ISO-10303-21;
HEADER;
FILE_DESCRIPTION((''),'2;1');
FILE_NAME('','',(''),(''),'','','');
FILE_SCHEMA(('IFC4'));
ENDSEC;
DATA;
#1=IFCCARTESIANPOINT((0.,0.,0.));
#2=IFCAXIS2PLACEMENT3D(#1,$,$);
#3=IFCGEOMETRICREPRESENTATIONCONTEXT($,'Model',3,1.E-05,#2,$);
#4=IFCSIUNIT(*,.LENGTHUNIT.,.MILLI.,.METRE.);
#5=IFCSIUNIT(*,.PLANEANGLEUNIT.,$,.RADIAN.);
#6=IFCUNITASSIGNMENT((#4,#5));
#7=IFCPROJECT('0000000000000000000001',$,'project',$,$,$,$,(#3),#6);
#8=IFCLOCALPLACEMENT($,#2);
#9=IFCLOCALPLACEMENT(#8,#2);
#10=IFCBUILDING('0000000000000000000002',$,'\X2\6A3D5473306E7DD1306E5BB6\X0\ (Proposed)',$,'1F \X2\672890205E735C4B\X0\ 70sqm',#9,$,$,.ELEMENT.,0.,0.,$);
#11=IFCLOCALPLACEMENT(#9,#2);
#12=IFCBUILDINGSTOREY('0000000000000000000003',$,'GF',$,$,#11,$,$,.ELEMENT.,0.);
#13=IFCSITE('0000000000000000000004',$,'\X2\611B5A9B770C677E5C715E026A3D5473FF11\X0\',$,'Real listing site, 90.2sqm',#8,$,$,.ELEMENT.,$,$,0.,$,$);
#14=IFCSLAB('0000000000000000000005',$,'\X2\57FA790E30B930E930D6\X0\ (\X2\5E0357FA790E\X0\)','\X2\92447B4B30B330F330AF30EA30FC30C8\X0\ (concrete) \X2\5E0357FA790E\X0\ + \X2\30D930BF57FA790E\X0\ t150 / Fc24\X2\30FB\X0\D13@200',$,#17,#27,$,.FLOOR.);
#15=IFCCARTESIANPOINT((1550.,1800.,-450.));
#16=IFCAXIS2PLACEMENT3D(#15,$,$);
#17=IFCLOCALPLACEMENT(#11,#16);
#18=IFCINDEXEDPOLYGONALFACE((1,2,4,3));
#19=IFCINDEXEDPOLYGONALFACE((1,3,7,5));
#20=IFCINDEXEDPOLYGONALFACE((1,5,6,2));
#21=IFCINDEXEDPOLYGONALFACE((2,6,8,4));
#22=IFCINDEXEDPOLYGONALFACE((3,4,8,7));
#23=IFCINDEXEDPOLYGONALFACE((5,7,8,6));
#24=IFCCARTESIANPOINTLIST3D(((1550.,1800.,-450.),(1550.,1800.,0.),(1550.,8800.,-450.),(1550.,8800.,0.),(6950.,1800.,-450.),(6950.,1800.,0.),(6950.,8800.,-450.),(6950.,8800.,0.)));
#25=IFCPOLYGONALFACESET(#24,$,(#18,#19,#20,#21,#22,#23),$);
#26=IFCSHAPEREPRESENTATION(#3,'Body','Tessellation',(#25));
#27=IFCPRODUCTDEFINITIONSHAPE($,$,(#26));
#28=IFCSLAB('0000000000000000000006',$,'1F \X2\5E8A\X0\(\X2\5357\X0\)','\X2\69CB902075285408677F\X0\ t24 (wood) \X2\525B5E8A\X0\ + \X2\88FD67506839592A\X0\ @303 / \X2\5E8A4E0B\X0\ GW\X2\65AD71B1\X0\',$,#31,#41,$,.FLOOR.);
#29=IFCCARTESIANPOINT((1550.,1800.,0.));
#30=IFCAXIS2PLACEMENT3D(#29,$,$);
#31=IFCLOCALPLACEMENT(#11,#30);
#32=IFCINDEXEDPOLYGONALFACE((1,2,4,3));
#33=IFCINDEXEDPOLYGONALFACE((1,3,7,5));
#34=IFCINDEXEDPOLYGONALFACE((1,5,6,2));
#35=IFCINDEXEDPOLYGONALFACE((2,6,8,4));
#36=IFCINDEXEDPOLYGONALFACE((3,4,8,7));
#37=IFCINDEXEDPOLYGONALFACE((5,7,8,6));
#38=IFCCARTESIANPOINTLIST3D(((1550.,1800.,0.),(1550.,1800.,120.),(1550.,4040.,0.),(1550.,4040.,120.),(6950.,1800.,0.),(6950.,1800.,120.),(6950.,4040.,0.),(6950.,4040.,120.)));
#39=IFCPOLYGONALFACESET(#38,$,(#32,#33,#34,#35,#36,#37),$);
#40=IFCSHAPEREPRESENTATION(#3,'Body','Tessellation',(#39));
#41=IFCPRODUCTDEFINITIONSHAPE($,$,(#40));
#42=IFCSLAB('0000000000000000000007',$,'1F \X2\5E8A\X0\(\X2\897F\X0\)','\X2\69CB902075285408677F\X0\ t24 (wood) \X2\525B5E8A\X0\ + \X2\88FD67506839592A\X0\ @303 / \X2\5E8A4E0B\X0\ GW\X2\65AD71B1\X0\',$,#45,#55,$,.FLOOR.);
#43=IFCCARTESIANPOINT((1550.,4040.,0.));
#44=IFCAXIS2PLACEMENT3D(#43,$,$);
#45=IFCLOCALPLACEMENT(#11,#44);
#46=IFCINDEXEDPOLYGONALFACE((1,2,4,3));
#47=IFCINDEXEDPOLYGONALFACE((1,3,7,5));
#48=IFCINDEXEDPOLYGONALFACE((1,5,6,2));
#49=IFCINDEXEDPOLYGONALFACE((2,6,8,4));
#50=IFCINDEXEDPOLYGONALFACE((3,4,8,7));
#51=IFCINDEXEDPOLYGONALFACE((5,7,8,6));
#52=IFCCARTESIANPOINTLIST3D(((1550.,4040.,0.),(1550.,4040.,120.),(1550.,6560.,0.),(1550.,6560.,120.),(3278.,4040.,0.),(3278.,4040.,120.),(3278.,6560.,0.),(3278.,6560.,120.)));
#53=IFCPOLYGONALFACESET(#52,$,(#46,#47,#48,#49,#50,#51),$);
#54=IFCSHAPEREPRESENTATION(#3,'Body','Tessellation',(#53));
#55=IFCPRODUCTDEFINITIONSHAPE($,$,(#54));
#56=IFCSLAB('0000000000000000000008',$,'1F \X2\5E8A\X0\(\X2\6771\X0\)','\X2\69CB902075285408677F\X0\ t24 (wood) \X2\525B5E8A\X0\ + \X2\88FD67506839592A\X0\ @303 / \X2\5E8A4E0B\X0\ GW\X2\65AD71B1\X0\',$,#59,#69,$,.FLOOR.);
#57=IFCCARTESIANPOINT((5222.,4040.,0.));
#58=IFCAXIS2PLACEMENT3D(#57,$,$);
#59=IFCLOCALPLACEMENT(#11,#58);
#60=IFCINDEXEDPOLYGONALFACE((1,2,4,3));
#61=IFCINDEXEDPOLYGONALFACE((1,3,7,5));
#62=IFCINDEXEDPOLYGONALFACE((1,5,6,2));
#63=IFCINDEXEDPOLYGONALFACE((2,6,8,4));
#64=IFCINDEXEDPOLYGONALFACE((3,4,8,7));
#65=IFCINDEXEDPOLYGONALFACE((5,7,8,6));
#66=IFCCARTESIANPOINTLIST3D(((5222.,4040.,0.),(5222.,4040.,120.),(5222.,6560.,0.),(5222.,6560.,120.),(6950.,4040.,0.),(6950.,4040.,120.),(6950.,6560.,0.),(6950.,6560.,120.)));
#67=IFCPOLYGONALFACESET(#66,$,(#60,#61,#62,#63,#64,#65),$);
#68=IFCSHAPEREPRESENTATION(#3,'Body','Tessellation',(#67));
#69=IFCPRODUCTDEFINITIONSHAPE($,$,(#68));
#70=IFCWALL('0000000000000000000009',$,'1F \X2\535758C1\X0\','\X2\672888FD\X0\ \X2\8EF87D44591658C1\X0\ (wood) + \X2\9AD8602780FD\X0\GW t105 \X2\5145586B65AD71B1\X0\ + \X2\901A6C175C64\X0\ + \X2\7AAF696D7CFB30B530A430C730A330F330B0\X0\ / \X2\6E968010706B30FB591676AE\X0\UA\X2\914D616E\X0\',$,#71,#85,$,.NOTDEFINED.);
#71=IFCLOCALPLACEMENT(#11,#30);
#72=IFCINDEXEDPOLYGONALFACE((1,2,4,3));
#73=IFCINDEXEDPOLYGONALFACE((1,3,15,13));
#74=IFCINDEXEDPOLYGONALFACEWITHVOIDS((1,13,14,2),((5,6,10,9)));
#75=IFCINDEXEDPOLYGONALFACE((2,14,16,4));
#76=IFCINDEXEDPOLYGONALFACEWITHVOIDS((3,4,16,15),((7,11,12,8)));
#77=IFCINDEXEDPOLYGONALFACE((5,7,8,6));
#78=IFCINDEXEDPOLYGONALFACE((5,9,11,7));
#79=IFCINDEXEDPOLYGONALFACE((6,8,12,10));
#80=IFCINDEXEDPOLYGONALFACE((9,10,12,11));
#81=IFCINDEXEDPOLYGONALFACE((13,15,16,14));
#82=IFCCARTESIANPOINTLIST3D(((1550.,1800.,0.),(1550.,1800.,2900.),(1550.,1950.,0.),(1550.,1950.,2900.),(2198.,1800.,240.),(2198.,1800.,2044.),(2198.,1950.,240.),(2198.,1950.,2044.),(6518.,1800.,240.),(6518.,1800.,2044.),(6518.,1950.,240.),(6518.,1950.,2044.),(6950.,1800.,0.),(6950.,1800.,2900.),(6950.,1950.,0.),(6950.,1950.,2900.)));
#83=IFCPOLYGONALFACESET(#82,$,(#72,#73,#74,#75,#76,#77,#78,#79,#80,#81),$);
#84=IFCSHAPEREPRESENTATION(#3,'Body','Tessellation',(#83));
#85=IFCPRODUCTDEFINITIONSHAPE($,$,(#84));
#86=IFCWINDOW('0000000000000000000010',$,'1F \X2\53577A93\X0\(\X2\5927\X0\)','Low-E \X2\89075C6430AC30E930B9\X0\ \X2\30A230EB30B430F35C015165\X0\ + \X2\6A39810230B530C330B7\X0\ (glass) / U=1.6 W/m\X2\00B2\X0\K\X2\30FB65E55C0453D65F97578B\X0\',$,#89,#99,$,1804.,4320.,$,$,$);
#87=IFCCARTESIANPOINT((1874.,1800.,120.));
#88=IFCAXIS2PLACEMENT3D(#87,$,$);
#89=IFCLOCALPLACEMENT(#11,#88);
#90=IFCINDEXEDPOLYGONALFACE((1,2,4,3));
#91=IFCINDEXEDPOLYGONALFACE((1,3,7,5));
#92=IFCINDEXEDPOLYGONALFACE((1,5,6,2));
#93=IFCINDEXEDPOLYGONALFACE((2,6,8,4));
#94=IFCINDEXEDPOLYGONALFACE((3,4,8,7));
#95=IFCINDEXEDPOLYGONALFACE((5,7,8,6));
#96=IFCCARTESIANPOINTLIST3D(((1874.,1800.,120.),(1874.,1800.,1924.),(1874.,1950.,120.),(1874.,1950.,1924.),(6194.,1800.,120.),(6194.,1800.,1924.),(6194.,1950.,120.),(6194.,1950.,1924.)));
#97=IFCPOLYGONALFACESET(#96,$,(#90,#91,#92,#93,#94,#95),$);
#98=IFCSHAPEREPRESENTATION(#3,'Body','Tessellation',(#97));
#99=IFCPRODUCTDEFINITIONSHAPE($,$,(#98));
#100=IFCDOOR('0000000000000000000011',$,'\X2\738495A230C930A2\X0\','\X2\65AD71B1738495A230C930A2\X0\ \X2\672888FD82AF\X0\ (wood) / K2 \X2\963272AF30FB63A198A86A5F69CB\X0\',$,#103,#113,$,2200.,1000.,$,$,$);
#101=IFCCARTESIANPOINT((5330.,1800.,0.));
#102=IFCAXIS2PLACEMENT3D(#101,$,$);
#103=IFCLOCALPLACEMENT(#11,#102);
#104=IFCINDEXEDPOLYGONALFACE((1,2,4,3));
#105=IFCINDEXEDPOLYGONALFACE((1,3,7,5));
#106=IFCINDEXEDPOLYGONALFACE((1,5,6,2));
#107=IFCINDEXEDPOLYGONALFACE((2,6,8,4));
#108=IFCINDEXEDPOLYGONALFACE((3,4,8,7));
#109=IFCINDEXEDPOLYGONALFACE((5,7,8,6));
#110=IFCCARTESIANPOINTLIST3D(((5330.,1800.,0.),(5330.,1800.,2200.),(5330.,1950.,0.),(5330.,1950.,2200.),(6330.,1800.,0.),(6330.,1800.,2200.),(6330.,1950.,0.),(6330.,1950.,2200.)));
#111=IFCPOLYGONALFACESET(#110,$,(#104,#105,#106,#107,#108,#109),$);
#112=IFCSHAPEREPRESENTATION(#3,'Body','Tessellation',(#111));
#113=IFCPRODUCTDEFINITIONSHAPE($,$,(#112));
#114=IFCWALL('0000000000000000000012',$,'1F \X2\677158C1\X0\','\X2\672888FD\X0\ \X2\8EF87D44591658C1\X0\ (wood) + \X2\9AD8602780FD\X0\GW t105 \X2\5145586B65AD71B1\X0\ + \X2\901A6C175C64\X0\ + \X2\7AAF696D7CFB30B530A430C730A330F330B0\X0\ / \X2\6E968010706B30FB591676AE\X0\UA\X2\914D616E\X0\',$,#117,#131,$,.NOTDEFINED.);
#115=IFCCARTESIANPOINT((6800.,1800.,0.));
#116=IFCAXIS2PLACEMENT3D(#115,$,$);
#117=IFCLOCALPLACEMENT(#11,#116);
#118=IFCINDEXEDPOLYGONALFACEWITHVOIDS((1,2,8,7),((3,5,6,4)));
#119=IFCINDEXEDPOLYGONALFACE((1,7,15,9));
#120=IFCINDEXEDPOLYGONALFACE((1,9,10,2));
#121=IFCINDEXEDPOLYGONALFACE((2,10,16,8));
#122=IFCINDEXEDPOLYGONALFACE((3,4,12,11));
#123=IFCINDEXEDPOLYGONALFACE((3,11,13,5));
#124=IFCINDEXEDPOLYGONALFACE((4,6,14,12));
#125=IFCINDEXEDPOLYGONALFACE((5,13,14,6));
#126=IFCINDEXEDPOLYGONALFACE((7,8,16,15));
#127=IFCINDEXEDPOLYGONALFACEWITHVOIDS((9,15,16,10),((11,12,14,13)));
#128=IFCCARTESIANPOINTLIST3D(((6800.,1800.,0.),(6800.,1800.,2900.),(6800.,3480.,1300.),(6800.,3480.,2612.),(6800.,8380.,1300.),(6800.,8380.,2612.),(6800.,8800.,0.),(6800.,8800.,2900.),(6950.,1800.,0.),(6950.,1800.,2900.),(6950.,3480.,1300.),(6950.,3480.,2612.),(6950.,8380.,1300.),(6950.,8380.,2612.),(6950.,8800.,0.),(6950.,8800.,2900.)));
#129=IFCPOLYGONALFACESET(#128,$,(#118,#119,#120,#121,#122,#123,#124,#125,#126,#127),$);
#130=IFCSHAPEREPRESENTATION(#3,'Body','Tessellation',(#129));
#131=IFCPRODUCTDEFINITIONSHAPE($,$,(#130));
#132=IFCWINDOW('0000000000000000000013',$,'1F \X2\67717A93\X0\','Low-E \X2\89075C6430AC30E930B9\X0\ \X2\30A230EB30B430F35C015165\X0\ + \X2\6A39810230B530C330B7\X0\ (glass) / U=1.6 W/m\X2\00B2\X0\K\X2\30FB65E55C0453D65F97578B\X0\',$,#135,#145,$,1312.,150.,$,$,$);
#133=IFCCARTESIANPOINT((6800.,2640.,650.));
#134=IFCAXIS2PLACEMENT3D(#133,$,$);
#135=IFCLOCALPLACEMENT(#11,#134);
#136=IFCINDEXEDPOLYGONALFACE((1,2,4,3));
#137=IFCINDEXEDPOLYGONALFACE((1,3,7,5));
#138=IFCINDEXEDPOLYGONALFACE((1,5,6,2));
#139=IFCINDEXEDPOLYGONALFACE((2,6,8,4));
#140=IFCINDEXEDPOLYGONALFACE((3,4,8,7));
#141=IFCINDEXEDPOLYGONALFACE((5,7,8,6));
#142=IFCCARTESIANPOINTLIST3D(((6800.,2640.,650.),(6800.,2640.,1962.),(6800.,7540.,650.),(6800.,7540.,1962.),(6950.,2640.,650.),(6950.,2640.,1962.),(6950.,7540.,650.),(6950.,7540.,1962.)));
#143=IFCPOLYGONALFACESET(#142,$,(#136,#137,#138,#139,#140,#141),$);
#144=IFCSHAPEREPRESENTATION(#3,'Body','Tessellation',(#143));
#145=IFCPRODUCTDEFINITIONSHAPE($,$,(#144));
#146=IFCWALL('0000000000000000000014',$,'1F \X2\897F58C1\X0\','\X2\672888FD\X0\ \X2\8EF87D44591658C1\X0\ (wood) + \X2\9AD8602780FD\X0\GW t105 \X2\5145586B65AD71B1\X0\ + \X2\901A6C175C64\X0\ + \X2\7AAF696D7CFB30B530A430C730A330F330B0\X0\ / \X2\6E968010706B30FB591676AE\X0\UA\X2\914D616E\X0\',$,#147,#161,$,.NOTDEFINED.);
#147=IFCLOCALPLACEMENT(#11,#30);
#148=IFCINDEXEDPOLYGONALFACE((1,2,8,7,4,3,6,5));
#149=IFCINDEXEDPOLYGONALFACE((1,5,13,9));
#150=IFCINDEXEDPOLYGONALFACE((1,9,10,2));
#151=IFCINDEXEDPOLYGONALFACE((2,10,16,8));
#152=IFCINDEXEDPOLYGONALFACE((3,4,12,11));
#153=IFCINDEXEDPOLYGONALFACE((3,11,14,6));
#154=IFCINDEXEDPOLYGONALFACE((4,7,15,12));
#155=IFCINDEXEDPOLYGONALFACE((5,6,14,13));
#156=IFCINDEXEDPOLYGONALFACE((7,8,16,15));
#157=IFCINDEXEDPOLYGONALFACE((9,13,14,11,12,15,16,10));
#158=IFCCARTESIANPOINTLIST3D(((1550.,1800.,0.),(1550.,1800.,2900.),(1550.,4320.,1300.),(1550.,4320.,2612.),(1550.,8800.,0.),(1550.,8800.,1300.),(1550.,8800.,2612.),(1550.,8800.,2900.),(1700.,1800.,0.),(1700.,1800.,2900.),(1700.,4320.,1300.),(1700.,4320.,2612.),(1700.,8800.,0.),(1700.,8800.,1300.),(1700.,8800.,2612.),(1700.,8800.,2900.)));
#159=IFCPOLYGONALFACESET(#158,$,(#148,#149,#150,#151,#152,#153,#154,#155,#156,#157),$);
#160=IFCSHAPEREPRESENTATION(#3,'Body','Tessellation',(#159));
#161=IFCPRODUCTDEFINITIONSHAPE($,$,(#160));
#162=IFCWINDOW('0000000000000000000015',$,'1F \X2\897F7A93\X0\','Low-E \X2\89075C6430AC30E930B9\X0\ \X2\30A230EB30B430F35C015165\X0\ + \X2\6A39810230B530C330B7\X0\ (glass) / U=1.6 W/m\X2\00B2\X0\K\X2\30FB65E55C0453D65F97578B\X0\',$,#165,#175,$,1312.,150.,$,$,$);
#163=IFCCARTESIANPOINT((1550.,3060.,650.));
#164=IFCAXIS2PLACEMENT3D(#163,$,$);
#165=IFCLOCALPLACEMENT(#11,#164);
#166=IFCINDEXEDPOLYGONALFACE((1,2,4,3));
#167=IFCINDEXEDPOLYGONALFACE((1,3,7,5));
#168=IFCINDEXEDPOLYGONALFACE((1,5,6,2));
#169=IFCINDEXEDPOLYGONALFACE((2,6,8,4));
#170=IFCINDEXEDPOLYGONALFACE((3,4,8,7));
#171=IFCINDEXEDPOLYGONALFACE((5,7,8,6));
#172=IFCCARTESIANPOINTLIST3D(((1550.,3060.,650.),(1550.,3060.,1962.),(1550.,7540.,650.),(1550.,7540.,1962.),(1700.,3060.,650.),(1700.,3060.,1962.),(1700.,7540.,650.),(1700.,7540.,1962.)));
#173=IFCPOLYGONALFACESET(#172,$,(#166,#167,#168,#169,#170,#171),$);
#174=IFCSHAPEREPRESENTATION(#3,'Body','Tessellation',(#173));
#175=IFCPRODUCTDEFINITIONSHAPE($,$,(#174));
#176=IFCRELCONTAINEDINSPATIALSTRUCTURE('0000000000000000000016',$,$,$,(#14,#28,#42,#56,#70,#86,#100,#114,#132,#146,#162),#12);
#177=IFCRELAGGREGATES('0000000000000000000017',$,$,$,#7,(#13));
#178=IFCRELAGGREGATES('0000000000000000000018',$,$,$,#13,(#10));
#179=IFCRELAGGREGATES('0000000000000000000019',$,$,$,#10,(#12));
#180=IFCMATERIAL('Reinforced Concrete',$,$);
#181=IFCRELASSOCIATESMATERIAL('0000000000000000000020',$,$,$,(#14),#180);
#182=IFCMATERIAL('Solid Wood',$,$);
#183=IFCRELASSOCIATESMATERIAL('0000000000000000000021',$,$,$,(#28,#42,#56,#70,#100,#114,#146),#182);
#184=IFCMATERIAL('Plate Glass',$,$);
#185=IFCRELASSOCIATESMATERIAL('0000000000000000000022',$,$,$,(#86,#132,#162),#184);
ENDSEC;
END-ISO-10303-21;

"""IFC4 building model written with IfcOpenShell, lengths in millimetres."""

from ifc_helpers import new_model, si_unit, frame, frame_2d, origin, place, context, project, spatial, rectangle, extrude, material, element, fill, save


model = new_model("IFC4")

# Units and contexts
model_context = context("Model", 3, precision=1e-05, world=origin())
ifc_project = project(units=[si_unit("LENGTHUNIT", "METRE", prefix="MILLI"), si_unit("PLANEANGLEUNIT", "RADIAN")], contexts=[model_context])

# Site, building, storey
site_placement = place(None, origin())
site = spatial("IfcSite", under=ifc_project, at=site_placement, Name="愛媛県松山市樽味１", ObjectType="Real listing site, 90.2sqm", CompositionType="ELEMENT", RefElevation=0.0)
building_placement = place(site_placement, origin())
building = spatial("IfcBuilding", under=site, at=building_placement, Name="樽味の緑の家 (Proposed)", ObjectType="1F 木造平屋 70sqm", CompositionType="ELEMENT", ElevationOfRefHeight=0.0, ElevationOfTerrain=0.0)
storey_placement = place(building_placement, origin())
storey = spatial("IfcBuildingStorey", under=building, at=storey_placement, Name="GF", CompositionType="ELEMENT", Elevation=0.0)

# Slabs
ifc_material_1 = material(Name="Reinforced Concrete")
slab_1_placement = place(storey_placement, frame((1550.0, 1800.0, -450.0)))
element("IfcSlab", 1, at=slab_1_placement, inside=storey, material=ifc_material_1, Name="基礎スラブ (布基礎)", Description="鉄筋コンクリート (concrete) 布基礎 + ベタ基礎 t150 / Fc24・D13@200", PredefinedType="FLOOR", context=model_context, shape_type="SweptSolid", body=[
    extrude(rectangle(XDim=5400.0, YDim=7000.0, at=frame_2d((2700.0, 3500.0))), frame((1550.0, 1800.0, -450.0)), (0.0, 0.0, 1.0), 450.0),
])
ifc_material_2 = material(Name="Solid Wood")
slab_2_placement = place(storey_placement, frame((1550.0, 1800.0, 0.0)))
element("IfcSlab", 2, at=slab_2_placement, inside=storey, material=ifc_material_2, Name="1F 床(南)", Description="構造用合板 t24 (wood) 剛床 + 製材根太 @303 / 床下 GW断熱", PredefinedType="FLOOR", context=model_context, shape_type="SweptSolid", body=[
    extrude(rectangle(XDim=5400.0, YDim=2240.0, at=frame_2d((2700.0, 1120.0))), frame((1550.0, 1800.0, 0.0)), (0.0, 0.0, 1.0), 120.0),
])
slab_3_placement = place(storey_placement, frame((1550.0, 4040.0, 0.0)))
element("IfcSlab", 3, at=slab_3_placement, inside=storey, material=ifc_material_2, Name="1F 床(西)", Description="構造用合板 t24 (wood) 剛床 + 製材根太 @303 / 床下 GW断熱", PredefinedType="FLOOR", context=model_context, shape_type="SweptSolid", body=[
    extrude(rectangle(XDim=1728.0, YDim=2520.0, at=frame_2d((864.0, 1260.0))), frame((1550.0, 4040.0, 0.0)), (0.0, 0.0, 1.0), 120.0),
])
slab_4_placement = place(storey_placement, frame((5222.0, 4040.0, 0.0)))
element("IfcSlab", 4, at=slab_4_placement, inside=storey, material=ifc_material_2, Name="1F 床(東)", Description="構造用合板 t24 (wood) 剛床 + 製材根太 @303 / 床下 GW断熱", PredefinedType="FLOOR", context=model_context, shape_type="SweptSolid", body=[
    extrude(rectangle(XDim=1728.0, YDim=2520.0, at=frame_2d((864.0, 1260.0))), frame((5222.0, 4040.0, 0.0)), (0.0, 0.0, 1.0), 120.0),
])

# Wall, openings, window, door
wall_1_placement = place(storey_placement, frame((1550.0, 1800.0, 0.0)))
wall_1 = element("IfcWall", 5, at=wall_1_placement, inside=storey, material=ifc_material_2, Name="1F 南壁", Description="木製 軸組外壁 (wood) + 高性能GW t105 充填断熱 + 通気層 + 窯業系サイディング / 準耐火・外皮UA配慮", PredefinedType="NOTDEFINED", context=model_context, shape_type="SweptSolid", body=[
    extrude(rectangle(XDim=5400.0, YDim=150.0, at=frame_2d((2700.0, 75.0))), frame((1550.0, 1800.0, 0.0)), (0.0, 0.0, 1.0), 2900.0),
])
opening_1_placement = place(storey_placement, frame((1874.0, 1800.0, 120.0)))
opening_1 = element("IfcOpeningElement", 6, at=opening_1_placement, cuts=wall_1, PredefinedType="NOTDEFINED", context=model_context, shape_type="SweptSolid", body=[
    extrude(rectangle(XDim=4320.0, YDim=150.0, at=frame_2d((2160.0, 75.0))), frame((1874.0, 1800.0, 120.0)), (0.0, 0.0, 1.0), 1804.0),
])
opening_2_placement = place(storey_placement, frame((5330.0, 1800.0, 0.0)))
opening_2 = element("IfcOpeningElement", 7, at=opening_2_placement, cuts=wall_1, PredefinedType="NOTDEFINED", context=model_context, shape_type="SweptSolid", body=[
    extrude(rectangle(XDim=1000.0, YDim=150.0, at=frame_2d((500.0, 75.0))), frame((5330.0, 1800.0, 0.0)), (0.0, 0.0, 1.0), 2200.0),
])
ifc_material_3 = material(Name="Plate Glass")
window_1_placement = place(storey_placement, frame((1874.0, 1800.0, 120.0)))
window_1 = element("IfcWindow", 8, at=window_1_placement, inside=storey, material=ifc_material_3, Name="1F 南窓(大)", Description="Low-E 複層ガラス アルゴン封入 + 樹脂サッシ (glass) / U=1.6 W/m²K・日射取得型", OverallHeight=1804.0, OverallWidth=4320.0, context=model_context, shape_type="SweptSolid", body=[
    extrude(rectangle(XDim=4320.0, YDim=150.0, at=frame_2d((2160.0, 75.0))), frame((1874.0, 1800.0, 120.0)), (0.0, 0.0, 1.0), 1804.0),
])
fill(opening_1, window_1)
door_placement = place(storey_placement, frame((5330.0, 1800.0, 0.0)))
door = element("IfcDoor", 9, at=door_placement, inside=storey, material=ifc_material_2, Name="玄関ドア", Description="断熱玄関ドア 木製芯 (wood) / K2 防犯・採風機構", OverallHeight=2200.0, OverallWidth=1000.0, context=model_context, shape_type="SweptSolid", body=[
    extrude(rectangle(XDim=1000.0, YDim=150.0, at=frame_2d((500.0, 75.0))), frame((5330.0, 1800.0, 0.0)), (0.0, 0.0, 1.0), 2200.0),
])
fill(opening_2, door)

# Walls, openings, windows
wall_2_placement = place(storey_placement, frame((6800.0, 1800.0, 0.0)))
wall_2 = element("IfcWall", 10, at=wall_2_placement, inside=storey, material=ifc_material_2, Name="1F 東壁", Description="木製 軸組外壁 (wood) + 高性能GW t105 充填断熱 + 通気層 + 窯業系サイディング / 準耐火・外皮UA配慮", PredefinedType="NOTDEFINED", context=model_context, shape_type="SweptSolid", body=[
    extrude(rectangle(XDim=150.0, YDim=7000.0, at=frame_2d((75.0, 3500.0))), frame((6800.0, 1800.0, 0.0)), (0.0, 0.0, 1.0), 2900.0),
])
opening_3_placement = place(storey_placement, frame((6800.0, 2640.0, 650.0)))
opening_3 = element("IfcOpeningElement", 11, at=opening_3_placement, cuts=wall_2, PredefinedType="NOTDEFINED", context=model_context, shape_type="SweptSolid", body=[
    extrude(rectangle(XDim=150.0, YDim=4900.0, at=frame_2d((75.0, 2450.0))), frame((6800.0, 2640.0, 650.0)), (0.0, 0.0, 1.0), 1312.0),
])
window_2_placement = place(storey_placement, frame((6800.0, 2640.0, 650.0)))
window_2 = element("IfcWindow", 12, at=window_2_placement, inside=storey, material=ifc_material_3, Name="1F 東窓", Description="Low-E 複層ガラス アルゴン封入 + 樹脂サッシ (glass) / U=1.6 W/m²K・日射取得型", OverallHeight=1312.0, OverallWidth=150.0, context=model_context, shape_type="SweptSolid", body=[
    extrude(rectangle(XDim=150.0, YDim=4900.0, at=frame_2d((75.0, 2450.0))), frame((6800.0, 2640.0, 650.0)), (0.0, 0.0, 1.0), 1312.0),
])
fill(opening_3, window_2)
wall_3_placement = place(storey_placement, frame((1550.0, 1800.0, 0.0)))
wall_3 = element("IfcWall", 13, at=wall_3_placement, inside=storey, material=ifc_material_2, Name="1F 西壁", Description="木製 軸組外壁 (wood) + 高性能GW t105 充填断熱 + 通気層 + 窯業系サイディング / 準耐火・外皮UA配慮", PredefinedType="NOTDEFINED", context=model_context, shape_type="SweptSolid", body=[
    extrude(rectangle(XDim=150.0, YDim=7000.0, at=frame_2d((75.0, 3500.0))), frame((1550.0, 1800.0, 0.0)), (0.0, 0.0, 1.0), 2900.0),
])
opening_4_placement = place(storey_placement, frame((1550.0, 3060.0, 650.0)))
opening_4 = element("IfcOpeningElement", 14, at=opening_4_placement, cuts=wall_3, PredefinedType="NOTDEFINED", context=model_context, shape_type="SweptSolid", body=[
    extrude(rectangle(XDim=150.0, YDim=4480.0, at=frame_2d((75.0, 2240.0))), frame((1550.0, 3060.0, 650.0)), (0.0, 0.0, 1.0), 1312.0),
])
window_3_placement = place(storey_placement, frame((1550.0, 3060.0, 650.0)))
window_3 = element("IfcWindow", 15, at=window_3_placement, inside=storey, material=ifc_material_3, Name="1F 西窓", Description="Low-E 複層ガラス アルゴン封入 + 樹脂サッシ (glass) / U=1.6 W/m²K・日射取得型", OverallHeight=1312.0, OverallWidth=150.0, context=model_context, shape_type="SweptSolid", body=[
    extrude(rectangle(XDim=150.0, YDim=4480.0, at=frame_2d((75.0, 2240.0))), frame((1550.0, 3060.0, 650.0)), (0.0, 0.0, 1.0), 1312.0),
])
fill(opening_4, window_3)

save(model, "model.ifc")
